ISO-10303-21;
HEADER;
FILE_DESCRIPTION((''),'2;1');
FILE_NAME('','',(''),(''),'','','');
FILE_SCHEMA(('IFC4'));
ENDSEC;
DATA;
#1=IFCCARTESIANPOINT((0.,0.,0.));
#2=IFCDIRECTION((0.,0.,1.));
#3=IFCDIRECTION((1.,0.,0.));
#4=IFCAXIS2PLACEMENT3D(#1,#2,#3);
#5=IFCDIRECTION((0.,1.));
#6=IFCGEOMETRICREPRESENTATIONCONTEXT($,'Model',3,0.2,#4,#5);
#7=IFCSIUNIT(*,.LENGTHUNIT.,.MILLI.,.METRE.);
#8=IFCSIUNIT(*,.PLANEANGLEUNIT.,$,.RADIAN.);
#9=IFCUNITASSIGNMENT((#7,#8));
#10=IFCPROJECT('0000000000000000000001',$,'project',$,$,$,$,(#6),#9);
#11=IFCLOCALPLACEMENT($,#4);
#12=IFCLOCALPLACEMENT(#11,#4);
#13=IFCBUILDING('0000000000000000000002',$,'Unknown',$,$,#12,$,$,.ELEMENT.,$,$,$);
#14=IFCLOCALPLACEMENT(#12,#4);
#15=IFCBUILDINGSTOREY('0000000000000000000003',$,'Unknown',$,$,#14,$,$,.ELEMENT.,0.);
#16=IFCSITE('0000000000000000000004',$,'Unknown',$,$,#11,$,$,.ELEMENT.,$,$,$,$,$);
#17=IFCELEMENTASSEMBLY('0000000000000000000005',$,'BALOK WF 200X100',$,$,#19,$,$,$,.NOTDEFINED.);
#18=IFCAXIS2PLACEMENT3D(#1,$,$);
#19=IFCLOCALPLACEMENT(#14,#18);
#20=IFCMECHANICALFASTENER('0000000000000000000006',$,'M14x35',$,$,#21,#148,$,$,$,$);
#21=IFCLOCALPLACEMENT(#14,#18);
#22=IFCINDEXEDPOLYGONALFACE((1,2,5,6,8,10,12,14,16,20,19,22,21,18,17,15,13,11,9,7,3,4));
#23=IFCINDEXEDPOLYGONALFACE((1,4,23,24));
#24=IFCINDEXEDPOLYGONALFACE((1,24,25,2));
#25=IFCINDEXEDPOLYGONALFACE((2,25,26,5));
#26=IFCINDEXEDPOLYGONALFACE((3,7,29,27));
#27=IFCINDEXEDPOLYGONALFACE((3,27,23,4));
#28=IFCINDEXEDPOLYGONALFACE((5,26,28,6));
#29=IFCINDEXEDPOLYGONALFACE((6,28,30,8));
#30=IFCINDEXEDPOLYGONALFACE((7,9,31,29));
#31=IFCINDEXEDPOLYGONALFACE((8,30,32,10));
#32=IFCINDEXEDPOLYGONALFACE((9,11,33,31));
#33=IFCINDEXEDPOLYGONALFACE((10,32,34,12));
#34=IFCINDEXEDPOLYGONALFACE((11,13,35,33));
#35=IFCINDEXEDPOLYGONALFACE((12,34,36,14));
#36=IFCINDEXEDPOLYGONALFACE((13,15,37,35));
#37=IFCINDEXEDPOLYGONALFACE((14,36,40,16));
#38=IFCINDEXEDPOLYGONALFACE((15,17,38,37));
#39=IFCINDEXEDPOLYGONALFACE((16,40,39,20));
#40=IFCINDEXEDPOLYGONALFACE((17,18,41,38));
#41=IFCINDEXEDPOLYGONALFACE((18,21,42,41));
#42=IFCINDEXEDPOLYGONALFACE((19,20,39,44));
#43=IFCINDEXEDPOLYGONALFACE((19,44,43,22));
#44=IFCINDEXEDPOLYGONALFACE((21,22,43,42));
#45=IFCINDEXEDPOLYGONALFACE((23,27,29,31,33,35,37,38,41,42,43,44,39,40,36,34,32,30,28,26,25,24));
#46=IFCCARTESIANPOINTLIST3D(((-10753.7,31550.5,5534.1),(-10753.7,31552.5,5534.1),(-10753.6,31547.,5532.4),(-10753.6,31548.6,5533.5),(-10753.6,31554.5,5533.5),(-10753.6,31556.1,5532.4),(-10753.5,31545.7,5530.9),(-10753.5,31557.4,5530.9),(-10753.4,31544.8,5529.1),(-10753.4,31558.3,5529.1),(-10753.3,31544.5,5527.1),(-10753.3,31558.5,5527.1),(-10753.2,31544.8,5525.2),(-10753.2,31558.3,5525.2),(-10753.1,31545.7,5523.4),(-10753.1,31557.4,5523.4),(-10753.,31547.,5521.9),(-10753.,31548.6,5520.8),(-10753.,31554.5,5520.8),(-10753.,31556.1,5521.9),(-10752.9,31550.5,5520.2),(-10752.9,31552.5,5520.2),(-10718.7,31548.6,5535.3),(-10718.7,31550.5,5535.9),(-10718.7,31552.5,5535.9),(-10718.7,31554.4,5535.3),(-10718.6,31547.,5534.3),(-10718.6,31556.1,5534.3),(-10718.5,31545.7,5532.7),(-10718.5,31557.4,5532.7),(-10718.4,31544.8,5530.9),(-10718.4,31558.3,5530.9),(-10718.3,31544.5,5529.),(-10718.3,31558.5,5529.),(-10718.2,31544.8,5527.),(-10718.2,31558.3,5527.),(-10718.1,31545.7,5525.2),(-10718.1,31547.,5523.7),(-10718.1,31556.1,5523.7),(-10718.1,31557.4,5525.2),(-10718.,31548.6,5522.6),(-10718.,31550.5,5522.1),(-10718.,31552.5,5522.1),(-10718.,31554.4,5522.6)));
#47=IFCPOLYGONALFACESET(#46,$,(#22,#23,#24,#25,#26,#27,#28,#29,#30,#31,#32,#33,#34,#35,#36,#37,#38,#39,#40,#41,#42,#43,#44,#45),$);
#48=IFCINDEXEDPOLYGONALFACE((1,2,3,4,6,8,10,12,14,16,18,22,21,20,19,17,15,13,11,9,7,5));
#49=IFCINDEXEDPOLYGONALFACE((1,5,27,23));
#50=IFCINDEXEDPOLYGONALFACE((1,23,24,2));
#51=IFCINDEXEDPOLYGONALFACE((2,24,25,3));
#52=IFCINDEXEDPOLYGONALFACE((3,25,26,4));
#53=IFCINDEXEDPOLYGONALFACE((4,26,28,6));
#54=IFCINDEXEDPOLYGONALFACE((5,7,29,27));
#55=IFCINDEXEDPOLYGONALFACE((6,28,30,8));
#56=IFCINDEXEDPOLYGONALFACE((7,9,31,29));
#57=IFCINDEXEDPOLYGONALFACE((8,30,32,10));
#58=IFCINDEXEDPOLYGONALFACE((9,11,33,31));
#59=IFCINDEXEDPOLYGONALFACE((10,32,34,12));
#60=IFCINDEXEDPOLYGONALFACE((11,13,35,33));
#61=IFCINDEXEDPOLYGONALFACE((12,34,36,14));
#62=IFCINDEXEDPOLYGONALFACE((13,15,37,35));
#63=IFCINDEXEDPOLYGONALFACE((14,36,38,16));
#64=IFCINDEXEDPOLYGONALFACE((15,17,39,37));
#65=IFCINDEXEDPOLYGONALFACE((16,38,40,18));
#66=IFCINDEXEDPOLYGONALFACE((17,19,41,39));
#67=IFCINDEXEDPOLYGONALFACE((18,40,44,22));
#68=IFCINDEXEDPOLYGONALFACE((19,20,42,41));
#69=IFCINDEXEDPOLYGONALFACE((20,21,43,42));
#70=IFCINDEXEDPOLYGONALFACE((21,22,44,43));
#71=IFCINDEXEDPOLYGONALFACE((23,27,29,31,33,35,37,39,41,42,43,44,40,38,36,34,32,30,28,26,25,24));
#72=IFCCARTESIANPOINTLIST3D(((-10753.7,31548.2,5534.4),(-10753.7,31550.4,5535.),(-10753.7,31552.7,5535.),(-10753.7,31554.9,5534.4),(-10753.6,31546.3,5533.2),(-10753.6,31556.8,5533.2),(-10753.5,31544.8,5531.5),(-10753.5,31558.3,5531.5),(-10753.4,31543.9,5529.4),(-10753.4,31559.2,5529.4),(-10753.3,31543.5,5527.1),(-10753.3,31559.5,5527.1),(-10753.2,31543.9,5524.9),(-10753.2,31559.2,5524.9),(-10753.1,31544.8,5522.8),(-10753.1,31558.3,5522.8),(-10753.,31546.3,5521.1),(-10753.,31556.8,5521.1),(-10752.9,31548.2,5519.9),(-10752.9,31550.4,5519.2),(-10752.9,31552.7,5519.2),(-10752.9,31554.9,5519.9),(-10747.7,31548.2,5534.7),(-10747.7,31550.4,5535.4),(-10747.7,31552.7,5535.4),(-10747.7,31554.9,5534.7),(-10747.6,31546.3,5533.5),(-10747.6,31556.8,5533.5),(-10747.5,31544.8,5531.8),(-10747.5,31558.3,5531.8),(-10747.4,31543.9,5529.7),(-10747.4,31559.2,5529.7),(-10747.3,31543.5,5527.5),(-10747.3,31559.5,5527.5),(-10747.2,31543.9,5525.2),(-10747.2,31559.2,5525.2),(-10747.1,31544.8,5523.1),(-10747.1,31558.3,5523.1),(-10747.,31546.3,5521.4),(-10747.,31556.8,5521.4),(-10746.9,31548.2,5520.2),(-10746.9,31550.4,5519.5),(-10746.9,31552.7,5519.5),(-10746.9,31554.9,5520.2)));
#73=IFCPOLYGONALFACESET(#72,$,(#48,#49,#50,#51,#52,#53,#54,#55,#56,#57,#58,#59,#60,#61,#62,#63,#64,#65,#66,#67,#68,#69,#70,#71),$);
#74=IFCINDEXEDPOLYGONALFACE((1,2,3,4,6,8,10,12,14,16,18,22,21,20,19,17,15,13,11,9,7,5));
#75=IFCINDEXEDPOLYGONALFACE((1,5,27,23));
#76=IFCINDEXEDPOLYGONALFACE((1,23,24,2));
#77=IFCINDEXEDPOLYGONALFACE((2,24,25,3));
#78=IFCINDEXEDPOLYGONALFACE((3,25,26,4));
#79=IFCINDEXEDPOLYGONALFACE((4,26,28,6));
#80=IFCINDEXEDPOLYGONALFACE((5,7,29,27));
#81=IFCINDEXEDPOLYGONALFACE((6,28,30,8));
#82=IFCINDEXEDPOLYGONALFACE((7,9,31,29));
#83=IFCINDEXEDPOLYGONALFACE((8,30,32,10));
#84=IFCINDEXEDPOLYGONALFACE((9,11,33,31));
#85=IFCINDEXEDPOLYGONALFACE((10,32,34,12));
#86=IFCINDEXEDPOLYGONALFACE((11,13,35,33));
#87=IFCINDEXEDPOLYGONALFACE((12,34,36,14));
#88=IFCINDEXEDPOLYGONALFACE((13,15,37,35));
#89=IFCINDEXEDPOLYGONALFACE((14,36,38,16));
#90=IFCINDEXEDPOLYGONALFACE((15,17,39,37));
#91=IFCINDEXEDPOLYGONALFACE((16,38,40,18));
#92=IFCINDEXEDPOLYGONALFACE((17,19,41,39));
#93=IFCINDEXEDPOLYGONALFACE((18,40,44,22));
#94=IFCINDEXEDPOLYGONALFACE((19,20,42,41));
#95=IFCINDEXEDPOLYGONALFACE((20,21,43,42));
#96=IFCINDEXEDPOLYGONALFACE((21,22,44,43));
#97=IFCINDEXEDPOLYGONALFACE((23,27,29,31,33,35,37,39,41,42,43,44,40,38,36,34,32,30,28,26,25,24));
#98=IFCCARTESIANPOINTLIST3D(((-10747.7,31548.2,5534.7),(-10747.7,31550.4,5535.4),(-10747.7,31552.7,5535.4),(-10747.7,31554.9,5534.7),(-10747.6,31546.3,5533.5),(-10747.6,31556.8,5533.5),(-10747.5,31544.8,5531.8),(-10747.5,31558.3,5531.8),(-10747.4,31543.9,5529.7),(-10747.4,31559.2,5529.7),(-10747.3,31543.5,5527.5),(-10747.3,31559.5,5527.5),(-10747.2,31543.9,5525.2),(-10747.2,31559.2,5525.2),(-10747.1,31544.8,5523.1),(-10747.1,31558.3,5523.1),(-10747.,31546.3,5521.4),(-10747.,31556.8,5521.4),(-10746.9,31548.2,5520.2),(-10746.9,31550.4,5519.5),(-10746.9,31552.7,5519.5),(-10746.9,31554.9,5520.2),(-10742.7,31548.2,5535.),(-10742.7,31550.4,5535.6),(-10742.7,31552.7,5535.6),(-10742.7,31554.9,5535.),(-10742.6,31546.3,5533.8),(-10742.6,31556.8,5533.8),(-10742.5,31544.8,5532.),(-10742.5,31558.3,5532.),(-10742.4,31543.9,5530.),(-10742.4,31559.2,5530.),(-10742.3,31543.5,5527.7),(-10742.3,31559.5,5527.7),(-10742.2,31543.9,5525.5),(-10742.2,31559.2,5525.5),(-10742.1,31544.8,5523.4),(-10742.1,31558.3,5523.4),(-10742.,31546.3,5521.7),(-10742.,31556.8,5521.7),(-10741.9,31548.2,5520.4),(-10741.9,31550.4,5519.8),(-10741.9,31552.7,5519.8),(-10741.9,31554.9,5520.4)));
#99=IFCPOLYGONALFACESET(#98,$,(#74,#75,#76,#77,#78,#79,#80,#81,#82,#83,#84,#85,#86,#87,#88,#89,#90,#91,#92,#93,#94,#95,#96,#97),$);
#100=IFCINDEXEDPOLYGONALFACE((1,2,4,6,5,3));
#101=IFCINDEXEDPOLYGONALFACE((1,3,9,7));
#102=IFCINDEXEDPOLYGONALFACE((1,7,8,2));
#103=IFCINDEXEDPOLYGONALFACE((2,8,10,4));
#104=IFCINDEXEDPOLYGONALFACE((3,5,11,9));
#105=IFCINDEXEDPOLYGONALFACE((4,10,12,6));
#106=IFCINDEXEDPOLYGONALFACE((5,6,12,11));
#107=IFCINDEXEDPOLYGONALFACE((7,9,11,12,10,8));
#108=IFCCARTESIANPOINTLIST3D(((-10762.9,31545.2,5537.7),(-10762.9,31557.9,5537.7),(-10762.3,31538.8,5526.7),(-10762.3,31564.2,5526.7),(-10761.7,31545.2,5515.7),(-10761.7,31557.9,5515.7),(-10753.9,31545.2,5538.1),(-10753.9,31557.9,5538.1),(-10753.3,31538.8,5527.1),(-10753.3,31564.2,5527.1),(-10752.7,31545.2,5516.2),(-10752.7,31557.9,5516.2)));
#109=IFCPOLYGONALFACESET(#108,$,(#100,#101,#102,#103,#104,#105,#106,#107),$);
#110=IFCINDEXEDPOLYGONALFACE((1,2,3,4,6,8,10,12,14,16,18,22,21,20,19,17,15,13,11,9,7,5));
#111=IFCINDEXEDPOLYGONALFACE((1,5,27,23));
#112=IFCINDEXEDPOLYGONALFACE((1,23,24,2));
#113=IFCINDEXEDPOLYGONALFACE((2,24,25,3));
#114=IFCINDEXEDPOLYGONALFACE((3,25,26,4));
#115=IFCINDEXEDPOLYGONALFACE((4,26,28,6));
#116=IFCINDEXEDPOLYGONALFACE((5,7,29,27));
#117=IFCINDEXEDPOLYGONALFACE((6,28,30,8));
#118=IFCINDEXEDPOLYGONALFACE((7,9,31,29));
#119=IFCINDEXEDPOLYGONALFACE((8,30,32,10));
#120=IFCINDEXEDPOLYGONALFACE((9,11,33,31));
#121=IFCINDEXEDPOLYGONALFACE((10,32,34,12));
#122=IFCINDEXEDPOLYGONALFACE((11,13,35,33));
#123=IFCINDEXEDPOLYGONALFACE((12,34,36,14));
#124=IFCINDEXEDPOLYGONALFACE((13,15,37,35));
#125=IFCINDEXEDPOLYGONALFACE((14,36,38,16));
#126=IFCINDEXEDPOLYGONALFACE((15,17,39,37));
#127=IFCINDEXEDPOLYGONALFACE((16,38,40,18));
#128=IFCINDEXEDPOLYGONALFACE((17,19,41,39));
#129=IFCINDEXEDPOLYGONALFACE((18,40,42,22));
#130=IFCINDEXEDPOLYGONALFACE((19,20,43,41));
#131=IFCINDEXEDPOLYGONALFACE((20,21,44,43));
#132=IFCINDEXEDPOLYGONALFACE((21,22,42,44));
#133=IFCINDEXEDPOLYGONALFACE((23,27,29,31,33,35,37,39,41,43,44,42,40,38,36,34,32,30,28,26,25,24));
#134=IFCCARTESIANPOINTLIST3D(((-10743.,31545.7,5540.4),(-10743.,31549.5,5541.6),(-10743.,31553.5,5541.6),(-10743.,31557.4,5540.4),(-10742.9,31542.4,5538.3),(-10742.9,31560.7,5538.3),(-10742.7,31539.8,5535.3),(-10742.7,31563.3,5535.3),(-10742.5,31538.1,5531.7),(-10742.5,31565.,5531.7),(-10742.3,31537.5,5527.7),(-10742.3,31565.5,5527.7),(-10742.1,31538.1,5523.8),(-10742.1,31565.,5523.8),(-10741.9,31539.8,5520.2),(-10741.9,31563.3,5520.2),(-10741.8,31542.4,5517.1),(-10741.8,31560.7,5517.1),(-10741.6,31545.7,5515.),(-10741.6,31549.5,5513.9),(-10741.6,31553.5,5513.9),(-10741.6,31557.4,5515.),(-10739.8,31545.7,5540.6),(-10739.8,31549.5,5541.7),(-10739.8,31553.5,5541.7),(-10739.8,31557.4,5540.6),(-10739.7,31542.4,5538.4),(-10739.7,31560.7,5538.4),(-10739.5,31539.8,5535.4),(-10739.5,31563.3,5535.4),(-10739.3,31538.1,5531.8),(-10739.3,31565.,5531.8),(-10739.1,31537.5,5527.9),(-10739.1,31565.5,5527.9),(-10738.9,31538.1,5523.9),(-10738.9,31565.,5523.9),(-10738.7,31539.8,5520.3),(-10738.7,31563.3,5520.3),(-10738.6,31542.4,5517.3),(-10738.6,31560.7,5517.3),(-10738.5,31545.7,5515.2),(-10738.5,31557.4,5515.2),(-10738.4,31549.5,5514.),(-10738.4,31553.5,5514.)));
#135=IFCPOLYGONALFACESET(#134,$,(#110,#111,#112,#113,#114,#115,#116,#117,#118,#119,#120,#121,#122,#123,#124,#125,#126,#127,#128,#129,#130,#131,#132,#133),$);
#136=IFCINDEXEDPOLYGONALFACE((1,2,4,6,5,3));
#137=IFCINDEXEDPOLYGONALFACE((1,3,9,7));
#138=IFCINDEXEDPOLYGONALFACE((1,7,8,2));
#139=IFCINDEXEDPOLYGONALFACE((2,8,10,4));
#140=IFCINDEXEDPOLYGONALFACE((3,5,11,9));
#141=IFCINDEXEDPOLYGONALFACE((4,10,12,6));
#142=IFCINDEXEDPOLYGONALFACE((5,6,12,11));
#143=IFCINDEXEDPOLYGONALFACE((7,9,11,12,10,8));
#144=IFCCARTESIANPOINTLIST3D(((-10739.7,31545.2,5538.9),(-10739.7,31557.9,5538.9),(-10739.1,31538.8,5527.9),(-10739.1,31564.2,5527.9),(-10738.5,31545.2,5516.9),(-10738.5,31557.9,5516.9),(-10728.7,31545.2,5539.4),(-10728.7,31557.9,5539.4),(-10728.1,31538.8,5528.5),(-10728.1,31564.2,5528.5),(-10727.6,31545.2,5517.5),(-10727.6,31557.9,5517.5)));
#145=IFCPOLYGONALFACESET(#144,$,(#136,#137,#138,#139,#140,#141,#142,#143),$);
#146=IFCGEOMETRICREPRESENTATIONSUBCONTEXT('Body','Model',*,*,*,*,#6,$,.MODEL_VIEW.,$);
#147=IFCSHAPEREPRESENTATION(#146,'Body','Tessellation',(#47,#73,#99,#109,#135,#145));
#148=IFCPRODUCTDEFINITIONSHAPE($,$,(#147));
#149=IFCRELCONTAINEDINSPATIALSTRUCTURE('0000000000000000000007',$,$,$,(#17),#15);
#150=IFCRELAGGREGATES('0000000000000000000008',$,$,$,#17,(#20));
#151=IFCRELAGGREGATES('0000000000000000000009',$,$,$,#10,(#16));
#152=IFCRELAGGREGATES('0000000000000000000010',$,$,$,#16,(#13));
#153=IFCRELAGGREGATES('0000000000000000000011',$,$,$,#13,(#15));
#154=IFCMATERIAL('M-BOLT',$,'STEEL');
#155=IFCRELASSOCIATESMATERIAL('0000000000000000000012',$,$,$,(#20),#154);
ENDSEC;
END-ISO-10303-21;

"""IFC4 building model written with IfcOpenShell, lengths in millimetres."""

from ifc_helpers import new_model, si_unit, direction, frame, origin_with_axes, place, context, subcontext, project, spatial, line, arc, indexed_curve, outline, extrude, source, transform, mapped, material, element, aggregate, save


model = new_model("IFC4")

# Units and contexts
model_context = context("Model", 3, precision=0.2, world=origin_with_axes(), true_north=direction((0.0, 1.0)))
body_context = subcontext(model_context, "Body", "Model", "MODEL_VIEW")
ifc_project = project(units=[si_unit("LENGTHUNIT", "METRE", prefix="MILLI"), si_unit("PLANEANGLEUNIT", "RADIAN")], contexts=[model_context])

# Site, building, storey
site_placement = place(None, origin_with_axes())
site = spatial("IfcSite", under=ifc_project, at=site_placement, Name="Unknown", CompositionType="ELEMENT")
building_placement = place(site_placement, origin_with_axes())
building = spatial("IfcBuilding", under=site, at=building_placement, Name="Unknown", CompositionType="ELEMENT")
storey_placement = place(building_placement, origin_with_axes())
storey = spatial("IfcBuildingStorey", under=building, at=storey_placement, Name="Unknown", CompositionType="ELEMENT", Elevation=0.0)

# Element assembly
assembly_1_placement = place(storey_placement, frame((-7044.1, 31466.5, 5721.5), z_axis=(0.0, 1.0, 0.0), x_axis=(-0.99863, 0.0, -0.052336)))
assembly_1 = element("IfcElementAssembly", 1, at=assembly_1_placement, inside=storey, Name="BALOK WF 200X100", PredefinedType="NOTDEFINED")

# Mechanical fastener
ifc_material_1 = material(Name="M-BOLT", Category="STEEL")
shared_shape_1 = source(origin_with_axes(), body_context, "Body", "SweptSolid", [
    extrude(outline(indexed_curve([(7.0, 0.0), (0.0, 7.0), (-7.0, 0.0), (0.0, -7.0)], segments=[arc(1, 2, 3), arc(3, 4, 1)])), frame((0.0, 0.0, -2.6), z_axis=(0.0, 0.0, -1.0), x_axis=(0.0, 1.0, 0.0)), (0.0, 0.0, 1.0), 35.0),
    extrude(outline(indexed_curve([(8.0, 0.0), (0.0, 8.0), (-8.0, 0.0), (0.0, -8.0)], segments=[arc(1, 2, 3), arc(3, 4, 1)])), frame((0.0, 0.0, -2.6), z_axis=(0.0, 0.0, -1.0), x_axis=(0.0, 1.0, 0.0)), (0.0, 0.0, 1.0), 6.0),
    extrude(outline(indexed_curve([(8.0, 0.0), (0.0, 8.0), (-8.0, 0.0), (0.0, -8.0)], segments=[arc(1, 2, 3), arc(3, 4, 1)])), frame((0.0, 0.0, -8.6), z_axis=(0.0, 0.0, -1.0), x_axis=(0.0, 1.0, 0.0)), (0.0, 0.0, 1.0), 5.0),
    extrude(outline(indexed_curve([(12.7, 0.0), (6.4, 11.0), (-6.4, 11.0), (-12.7, 0.0), (-6.4, -11.0), (6.4, -11.0)], segments=[line(1, 2, 3, 4, 5, 6, 1)])), frame((0.0, 0.0, 6.4), z_axis=(0.0, 0.0, -1.0), x_axis=(0.0, 1.0, 0.0)), (0.0, 0.0, 1.0), 9.0),
    extrude(outline(indexed_curve([(14.0, 0.0), (0.0, 14.0), (-14.0, 0.0), (0.0, -14.0)], segments=[arc(1, 2, 3), arc(3, 4, 1)])), frame((0.0, 0.0, -13.6), z_axis=(0.0, 0.0, -1.0), x_axis=(0.0, 1.0, 0.0)), (0.0, 0.0, 1.0), 3.2),
    extrude(outline(indexed_curve([(12.7, 0.0), (6.4, 11.0), (-6.4, 11.0), (-12.7, 0.0), (-6.4, -11.0), (6.4, -11.0)], segments=[line(1, 2, 3, 4, 5, 6, 1)])), frame((0.0, 0.0, -16.8), z_axis=(0.0, 0.0, -1.0), x_axis=(0.0, 1.0, 0.0)), (0.0, 0.0, 1.0), 11.0),
])
mechanical_fastener_1_placement = place(assembly_1_placement, frame((3716.9, 0.1, 85.0), z_axis=(1.0, 0.0, 0.000006), x_axis=(0.0, -1.0, 0.0)))
mechanical_fastener_1 = element("IfcMechanicalFastener", 2, at=mechanical_fastener_1_placement, material=ifc_material_1, Name="M14x35", context=body_context, shape_type="MappedRepresentation", body=[
    mapped(shared_shape_1, transform((0.0, 0.0, 0.0))),
])

aggregate(assembly_1, [mechanical_fastener_1])

save(model, "model.ifc")
